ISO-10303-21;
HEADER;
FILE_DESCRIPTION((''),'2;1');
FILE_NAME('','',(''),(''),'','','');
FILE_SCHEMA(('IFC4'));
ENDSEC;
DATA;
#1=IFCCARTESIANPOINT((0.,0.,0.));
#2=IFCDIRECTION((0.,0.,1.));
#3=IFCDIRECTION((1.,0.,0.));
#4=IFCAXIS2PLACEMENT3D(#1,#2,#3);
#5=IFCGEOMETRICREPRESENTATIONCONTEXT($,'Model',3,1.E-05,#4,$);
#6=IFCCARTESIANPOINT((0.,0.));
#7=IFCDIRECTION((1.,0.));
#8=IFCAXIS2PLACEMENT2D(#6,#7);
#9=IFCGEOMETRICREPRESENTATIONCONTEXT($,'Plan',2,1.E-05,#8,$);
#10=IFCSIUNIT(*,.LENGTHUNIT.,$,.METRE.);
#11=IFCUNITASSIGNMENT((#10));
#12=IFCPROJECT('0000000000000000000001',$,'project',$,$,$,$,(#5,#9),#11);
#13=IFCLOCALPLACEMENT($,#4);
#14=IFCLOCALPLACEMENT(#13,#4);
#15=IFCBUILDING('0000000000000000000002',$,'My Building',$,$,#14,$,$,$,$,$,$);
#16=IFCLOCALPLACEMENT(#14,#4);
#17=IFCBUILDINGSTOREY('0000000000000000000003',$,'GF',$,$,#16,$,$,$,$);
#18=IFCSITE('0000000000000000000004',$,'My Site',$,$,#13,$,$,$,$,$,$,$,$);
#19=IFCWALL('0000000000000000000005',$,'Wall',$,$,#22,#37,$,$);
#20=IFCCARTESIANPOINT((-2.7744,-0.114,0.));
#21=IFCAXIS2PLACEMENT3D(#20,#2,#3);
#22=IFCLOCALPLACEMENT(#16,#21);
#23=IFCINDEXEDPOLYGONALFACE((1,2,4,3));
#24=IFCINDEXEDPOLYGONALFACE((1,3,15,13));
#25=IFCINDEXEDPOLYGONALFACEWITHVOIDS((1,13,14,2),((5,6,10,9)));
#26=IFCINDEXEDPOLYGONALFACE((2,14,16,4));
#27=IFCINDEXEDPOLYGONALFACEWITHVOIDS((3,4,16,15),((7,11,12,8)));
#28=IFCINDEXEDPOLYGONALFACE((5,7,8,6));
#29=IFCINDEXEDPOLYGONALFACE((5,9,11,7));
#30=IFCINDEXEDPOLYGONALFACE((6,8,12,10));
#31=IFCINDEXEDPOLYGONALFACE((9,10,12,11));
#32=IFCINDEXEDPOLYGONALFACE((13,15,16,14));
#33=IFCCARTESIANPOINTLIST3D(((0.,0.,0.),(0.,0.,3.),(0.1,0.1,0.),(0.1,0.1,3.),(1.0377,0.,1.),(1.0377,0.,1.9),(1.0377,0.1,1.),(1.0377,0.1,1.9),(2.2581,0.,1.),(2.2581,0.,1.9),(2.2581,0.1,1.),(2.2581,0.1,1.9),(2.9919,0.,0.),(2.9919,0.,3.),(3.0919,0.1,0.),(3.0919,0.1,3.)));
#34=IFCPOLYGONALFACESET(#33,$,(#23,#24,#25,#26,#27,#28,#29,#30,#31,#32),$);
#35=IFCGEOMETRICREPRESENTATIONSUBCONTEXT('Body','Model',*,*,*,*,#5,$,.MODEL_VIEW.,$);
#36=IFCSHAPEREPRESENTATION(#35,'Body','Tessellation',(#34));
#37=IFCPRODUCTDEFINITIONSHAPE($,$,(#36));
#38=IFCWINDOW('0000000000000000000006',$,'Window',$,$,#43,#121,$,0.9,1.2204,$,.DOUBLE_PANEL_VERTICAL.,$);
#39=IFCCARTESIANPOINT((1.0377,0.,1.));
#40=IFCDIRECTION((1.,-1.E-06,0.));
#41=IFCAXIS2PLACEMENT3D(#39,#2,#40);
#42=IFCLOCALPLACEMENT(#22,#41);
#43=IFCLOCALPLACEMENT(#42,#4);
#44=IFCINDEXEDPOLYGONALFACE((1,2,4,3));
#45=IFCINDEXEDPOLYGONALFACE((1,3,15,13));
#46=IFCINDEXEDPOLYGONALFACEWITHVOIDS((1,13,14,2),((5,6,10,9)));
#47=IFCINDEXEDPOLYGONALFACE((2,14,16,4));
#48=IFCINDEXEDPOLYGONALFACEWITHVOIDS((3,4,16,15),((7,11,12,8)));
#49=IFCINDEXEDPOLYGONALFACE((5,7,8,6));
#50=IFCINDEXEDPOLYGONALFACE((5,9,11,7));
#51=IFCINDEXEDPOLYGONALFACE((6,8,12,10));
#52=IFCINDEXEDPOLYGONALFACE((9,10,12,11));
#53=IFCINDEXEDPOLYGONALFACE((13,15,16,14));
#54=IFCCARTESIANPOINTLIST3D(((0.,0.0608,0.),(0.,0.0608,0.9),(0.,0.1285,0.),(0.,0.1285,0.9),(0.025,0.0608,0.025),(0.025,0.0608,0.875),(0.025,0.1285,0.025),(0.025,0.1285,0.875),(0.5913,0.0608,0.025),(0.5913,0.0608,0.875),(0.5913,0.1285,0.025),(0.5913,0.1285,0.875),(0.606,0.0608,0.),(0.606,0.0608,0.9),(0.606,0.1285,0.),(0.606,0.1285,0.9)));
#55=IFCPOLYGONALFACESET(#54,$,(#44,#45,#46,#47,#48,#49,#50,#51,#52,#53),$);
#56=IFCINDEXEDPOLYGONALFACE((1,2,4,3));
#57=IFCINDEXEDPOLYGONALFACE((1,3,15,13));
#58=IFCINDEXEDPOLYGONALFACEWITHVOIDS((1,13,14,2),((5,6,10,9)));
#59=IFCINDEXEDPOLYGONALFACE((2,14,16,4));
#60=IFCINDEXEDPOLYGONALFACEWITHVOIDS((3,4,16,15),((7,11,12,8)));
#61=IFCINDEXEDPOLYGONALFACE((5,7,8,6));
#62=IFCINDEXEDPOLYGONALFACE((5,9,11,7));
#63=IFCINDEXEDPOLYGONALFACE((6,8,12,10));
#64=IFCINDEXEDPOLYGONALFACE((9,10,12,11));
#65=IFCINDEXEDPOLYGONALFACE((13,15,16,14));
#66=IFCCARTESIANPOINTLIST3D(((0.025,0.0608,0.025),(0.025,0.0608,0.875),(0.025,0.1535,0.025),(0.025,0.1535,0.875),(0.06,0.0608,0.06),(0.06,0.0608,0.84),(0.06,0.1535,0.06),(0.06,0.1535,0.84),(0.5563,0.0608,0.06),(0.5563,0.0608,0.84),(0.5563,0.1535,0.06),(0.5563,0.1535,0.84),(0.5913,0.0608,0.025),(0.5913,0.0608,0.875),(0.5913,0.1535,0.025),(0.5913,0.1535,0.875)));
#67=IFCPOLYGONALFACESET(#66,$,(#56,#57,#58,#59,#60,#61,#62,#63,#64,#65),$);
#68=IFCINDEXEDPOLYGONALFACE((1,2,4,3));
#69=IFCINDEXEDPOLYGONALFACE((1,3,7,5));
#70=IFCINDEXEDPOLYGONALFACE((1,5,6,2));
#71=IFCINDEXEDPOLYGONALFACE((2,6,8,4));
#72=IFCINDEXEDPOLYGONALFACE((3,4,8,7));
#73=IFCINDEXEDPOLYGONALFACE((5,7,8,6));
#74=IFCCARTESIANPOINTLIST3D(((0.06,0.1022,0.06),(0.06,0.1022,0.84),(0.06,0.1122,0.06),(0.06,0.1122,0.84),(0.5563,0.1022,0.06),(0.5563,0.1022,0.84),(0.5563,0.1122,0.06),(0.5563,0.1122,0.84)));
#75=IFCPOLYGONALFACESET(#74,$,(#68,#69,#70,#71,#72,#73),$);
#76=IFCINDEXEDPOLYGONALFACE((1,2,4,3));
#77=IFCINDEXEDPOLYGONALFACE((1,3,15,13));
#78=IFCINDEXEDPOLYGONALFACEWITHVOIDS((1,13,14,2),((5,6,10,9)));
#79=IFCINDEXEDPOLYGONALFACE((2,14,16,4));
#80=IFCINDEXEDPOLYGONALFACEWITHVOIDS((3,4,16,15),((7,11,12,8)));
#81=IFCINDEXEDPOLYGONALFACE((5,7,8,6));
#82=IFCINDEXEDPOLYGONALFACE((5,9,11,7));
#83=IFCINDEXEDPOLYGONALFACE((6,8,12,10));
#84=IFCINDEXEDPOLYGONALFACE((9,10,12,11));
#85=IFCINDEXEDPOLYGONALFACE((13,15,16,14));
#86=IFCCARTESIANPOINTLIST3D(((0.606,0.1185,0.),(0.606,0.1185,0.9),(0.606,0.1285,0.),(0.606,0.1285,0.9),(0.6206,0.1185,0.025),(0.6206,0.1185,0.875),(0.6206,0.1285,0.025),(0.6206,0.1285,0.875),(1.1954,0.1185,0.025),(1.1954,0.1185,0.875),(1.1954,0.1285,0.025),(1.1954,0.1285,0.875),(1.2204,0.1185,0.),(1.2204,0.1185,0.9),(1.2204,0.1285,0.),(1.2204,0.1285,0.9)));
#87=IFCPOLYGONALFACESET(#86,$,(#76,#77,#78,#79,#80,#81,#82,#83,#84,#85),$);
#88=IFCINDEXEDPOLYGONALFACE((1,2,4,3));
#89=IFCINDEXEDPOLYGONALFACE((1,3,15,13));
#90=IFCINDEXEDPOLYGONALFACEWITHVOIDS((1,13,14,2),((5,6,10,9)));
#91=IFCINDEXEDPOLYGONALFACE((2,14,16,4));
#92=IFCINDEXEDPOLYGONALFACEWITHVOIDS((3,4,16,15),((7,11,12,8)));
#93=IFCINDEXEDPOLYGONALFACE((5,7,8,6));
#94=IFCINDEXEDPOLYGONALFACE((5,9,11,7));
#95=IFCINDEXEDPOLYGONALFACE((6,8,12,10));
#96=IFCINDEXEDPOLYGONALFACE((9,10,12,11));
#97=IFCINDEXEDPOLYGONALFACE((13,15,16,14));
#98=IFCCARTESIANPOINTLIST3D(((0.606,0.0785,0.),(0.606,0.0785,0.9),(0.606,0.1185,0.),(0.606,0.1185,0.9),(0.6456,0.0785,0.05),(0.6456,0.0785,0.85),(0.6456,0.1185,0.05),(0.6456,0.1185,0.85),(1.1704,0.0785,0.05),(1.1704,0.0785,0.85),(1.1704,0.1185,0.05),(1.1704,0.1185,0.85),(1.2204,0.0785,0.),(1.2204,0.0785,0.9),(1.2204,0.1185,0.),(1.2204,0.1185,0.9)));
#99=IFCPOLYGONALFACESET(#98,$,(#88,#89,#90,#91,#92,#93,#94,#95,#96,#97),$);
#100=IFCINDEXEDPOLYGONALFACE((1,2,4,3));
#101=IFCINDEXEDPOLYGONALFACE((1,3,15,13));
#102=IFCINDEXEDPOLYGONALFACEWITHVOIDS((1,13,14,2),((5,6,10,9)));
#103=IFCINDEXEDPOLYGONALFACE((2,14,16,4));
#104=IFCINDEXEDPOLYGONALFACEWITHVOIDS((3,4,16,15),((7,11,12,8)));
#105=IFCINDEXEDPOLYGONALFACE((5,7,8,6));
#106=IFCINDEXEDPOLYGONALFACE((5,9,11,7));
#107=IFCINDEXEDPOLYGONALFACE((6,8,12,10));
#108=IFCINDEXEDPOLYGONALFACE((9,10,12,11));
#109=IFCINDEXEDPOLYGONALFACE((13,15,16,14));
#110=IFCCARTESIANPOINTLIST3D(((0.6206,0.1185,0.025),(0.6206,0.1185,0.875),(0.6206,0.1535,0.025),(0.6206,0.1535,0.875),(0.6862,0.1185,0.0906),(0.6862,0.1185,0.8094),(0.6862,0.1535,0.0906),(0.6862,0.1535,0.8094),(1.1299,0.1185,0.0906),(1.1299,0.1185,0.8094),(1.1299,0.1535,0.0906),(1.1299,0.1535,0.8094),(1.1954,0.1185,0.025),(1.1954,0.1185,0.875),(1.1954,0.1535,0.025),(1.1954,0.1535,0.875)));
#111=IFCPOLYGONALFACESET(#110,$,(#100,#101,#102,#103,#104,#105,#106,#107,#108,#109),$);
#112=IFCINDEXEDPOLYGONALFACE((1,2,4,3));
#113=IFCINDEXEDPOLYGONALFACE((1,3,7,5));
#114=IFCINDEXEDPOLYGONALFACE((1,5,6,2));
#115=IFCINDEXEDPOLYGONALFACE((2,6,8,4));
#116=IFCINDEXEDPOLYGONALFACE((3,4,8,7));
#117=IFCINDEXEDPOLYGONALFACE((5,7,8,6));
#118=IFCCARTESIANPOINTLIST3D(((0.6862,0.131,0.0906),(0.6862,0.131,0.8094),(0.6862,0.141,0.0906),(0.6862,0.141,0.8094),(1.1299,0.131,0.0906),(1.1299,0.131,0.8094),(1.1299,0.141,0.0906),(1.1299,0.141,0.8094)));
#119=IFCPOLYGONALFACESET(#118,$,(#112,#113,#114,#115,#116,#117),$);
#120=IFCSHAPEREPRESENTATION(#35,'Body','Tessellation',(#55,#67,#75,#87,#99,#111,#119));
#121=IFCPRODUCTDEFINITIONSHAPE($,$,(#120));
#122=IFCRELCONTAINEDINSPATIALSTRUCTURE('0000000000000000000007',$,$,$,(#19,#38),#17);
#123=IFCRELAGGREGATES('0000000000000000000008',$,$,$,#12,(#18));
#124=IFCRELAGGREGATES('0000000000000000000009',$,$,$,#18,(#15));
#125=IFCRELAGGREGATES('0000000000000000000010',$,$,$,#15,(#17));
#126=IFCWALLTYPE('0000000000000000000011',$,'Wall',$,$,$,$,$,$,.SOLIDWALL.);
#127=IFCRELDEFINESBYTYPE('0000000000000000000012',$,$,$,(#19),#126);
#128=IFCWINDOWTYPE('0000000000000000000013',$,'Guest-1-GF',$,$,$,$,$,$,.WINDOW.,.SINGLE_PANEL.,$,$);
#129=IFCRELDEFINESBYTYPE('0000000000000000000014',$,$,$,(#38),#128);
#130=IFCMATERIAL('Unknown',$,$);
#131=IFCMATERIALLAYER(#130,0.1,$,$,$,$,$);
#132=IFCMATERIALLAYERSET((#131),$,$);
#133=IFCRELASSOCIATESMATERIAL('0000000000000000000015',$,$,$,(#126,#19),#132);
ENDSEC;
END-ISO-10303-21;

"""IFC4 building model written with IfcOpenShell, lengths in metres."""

from ifc_helpers import new_model, entity, si_unit, frame, origin_with_axes, origin_2d_with_axis, place, context, subcontext, project, spatial, line, indexed_curve, outline, extrude, shape, source, transform, mapped, material, layer, layer_set, layer_usage, type_object, type_shapes, element, fill, save


model = new_model("IFC4")

# Units and contexts
model_context = context("Model", 3, precision=1e-05, world=origin_with_axes())
plan_context = context("Plan", 2, precision=1e-05, world=origin_2d_with_axis())
body_context_1 = subcontext(model_context, "Body", "Model", "MODEL_VIEW")
body_context_2 = subcontext(plan_context, "Body", "Plan", "PLAN_VIEW")
ifc_project = project(units=[si_unit("LENGTHUNIT", "METRE")], contexts=[model_context, plan_context])

# Site, building, storey
site_placement = place(None, origin_with_axes())
site = spatial("IfcSite", under=ifc_project, at=site_placement, Name="My Site")
building_placement = place(site_placement, origin_with_axes())
building = spatial("IfcBuilding", under=site, at=building_placement, Name="My Building")
storey_placement = place(building_placement, origin_with_axes())
storey = spatial("IfcBuildingStorey", under=building, at=storey_placement, Name="GF")

# Shared definitions
ifc_material = material(Name="Unknown")

# Shared definitions
ifc_layer_1 = layer(ifc_material, 0.1)
ifc_layer_set_1 = layer_set([ifc_layer_1])
wall_type = type_object("IfcWallType", Name="Wall", PredefinedType="SOLIDWALL", material=ifc_layer_set_1)

# Wall, opening, window
ifc_layer_usage_1 = layer_usage(ifc_layer_set_1, "AXIS2", "POSITIVE", 0.0)
wall_1_placement = place(storey_placement, frame((-2.7744, -0.114, 0.0), z_axis=(0.0, 0.0, 1.0), x_axis=(1.0, 0.0, 0.0)))
wall_1 = element("IfcWall", 1, at=wall_1_placement, inside=storey, type_object=wall_type, material=ifc_layer_usage_1, Name="Wall", context=body_context_1, shape_type="SweptSolid", body=[
    extrude(outline(indexed_curve([(0.0, 0.0), (0.1, 0.1), (3.0919, 0.1), (2.9919, 0.0)], segments=[line(1, 2, 3, 4, 1)])), origin_with_axes(), (0.0, 0.0, 1.0), 3.0),
])
shared_shape_1 = source(origin_with_axes(), body_context_1, "Body", "SweptSolid", [
    extrude(outline(indexed_curve([(0.0, 0.0), (1.2204, 0.0), (1.2204, 0.9), (0.0, 0.9)], segments=[line(1, 2, 3, 4, 1)])), frame((0.0, -0.6, 0.0), z_axis=(0.0, -1.0, 0.0), x_axis=(1.0, 0.0, 0.0)), (0.0, 0.0, -1.0), 1.2),
])
opening_1_placement = place(wall_1_placement, frame((1.0377, 0.0, 1.0), z_axis=(0.0, 0.0, 1.0), x_axis=(1.0, -0.000001, 0.0)))
opening_1 = element("IfcOpeningElement", 2, at=opening_1_placement, cuts=wall_1, PredefinedType="OPENING", context=body_context_1, shape_type="MappedRepresentation", body=[
    mapped(shared_shape_1, transform((0.0, 0.0, 0.0), x_axis=(1.0, 0.0, 0.0), y_axis=(0.0, 1.0, 0.0), z_axis=(0.0, 0.0, 1.0), scale=1.0)),
])
window_type_1 = type_object("IfcWindowType", Name="Guest-1-GF", PartitioningType="SINGLE_PANEL", PredefinedType="WINDOW")
shared_shape_2 = source(origin_with_axes(), body_context_1, "Body", "SweptSolid", [
    extrude(outline(indexed_curve([(0.0, 0.0), (0.606, 0.0), (0.606, 0.9), (0.0, 0.9)], segments=[line(1, 2, 3, 4, 1)]), holes=[indexed_curve([(0.025, 0.025), (0.5913, 0.025), (0.5913, 0.875), (0.025, 0.875)], segments=[line(1, 2, 3, 4, 1)])]), frame((0.0, 0.0608, 0.0), z_axis=(0.0, -1.0, 0.0), x_axis=(1.0, 0.0, 0.0)), (0.0, 0.0, -1.0), 0.0677),
    extrude(outline(indexed_curve([(0.0, 0.0), (0.606, 0.0), (0.606, 0.9), (0.0, 0.9)], segments=[line(1, 2, 3, 4, 1)]), holes=[indexed_curve([(0.05, 0.05), (0.5663, 0.05), (0.5663, 0.85), (0.05, 0.85)], segments=[line(1, 2, 3, 4, 1)])]), frame((0.0, 0.0785, 0.0), z_axis=(0.0, -1.0, 0.0), x_axis=(1.0, 0.0, 0.0)), (0.0, 0.0, -1.0), -0.0177),
    extrude(outline(indexed_curve([(0.0, 0.0), (0.5663, 0.0), (0.5663, 0.85), (0.0, 0.85)], segments=[line(1, 2, 3, 4, 1)]), holes=[indexed_curve([(0.035, 0.035), (0.5313, 0.035), (0.5313, 0.815), (0.035, 0.815)], segments=[line(1, 2, 3, 4, 1)])]), frame((0.025, 0.0608, 0.025), z_axis=(0.0, -1.0, 0.0), x_axis=(1.0, 0.0, 0.0)), (0.0, 0.0, -1.0), 0.0927),
    extrude(outline(indexed_curve([(0.035, 0.035), (0.5313, 0.035), (0.5313, 0.815), (0.035, 0.815)], segments=[line(1, 2, 3, 4, 1)])), frame((0.025, 0.1022, 0.025), z_axis=(0.0, -1.0, 0.0), x_axis=(1.0, 0.0, 0.0)), (0.0, 0.0, -1.0), 0.01),
    extrude(outline(indexed_curve([(0.0, 0.0), (0.6144, 0.0), (0.6144, 0.9), (0.0, 0.9)], segments=[line(1, 2, 3, 4, 1)]), holes=[indexed_curve([(0.0147, 0.025), (0.5894, 0.025), (0.5894, 0.875), (0.0147, 0.875)], segments=[line(1, 2, 3, 4, 1)])]), frame((0.606, 0.1185, 0.0), z_axis=(0.0, -1.0, 0.0), x_axis=(1.0, 0.0, 0.0)), (0.0, 0.0, -1.0), 0.01),
    extrude(outline(indexed_curve([(0.0, 0.0), (0.6144, 0.0), (0.6144, 0.9), (0.0, 0.9)], segments=[line(1, 2, 3, 4, 1)]), holes=[indexed_curve([(0.0397, 0.05), (0.5644, 0.05), (0.5644, 0.85), (0.0397, 0.85)], segments=[line(1, 2, 3, 4, 1)])]), frame((0.606, 0.0785, 0.0), z_axis=(0.0, -1.0, 0.0), x_axis=(1.0, 0.0, 0.0)), (0.0, 0.0, -1.0), 0.04),
    extrude(outline(indexed_curve([(0.0, 0.0), (0.5748, 0.0), (0.5748, 0.85), (0.0, 0.85)], segments=[line(1, 2, 3, 4, 1)]), holes=[indexed_curve([(0.0656, 0.0656), (0.5092, 0.0656), (0.5092, 0.7844), (0.0656, 0.7844)], segments=[line(1, 2, 3, 4, 1)])]), frame((0.6206, 0.1185, 0.025), z_axis=(0.0, -1.0, 0.0), x_axis=(1.0, 0.0, 0.0)), (0.0, 0.0, -1.0), 0.035),
    extrude(outline(indexed_curve([(0.0656, 0.0656), (0.5092, 0.0656), (0.5092, 0.7844), (0.0656, 0.7844)], segments=[line(1, 2, 3, 4, 1)])), frame((0.6206, 0.131, 0.025), z_axis=(0.0, -1.0, 0.0), x_axis=(1.0, 0.0, 0.0)), (0.0, 0.0, -1.0), 0.01),
])
shared_shape_3 = source(origin_with_axes(), body_context_2, "Body", "Curve2D", [
    entity("IfcIndexedPolyCurve", entity("IfcCartesianPointList2D", [[0.05, 0.0785], [0.5663, 0.0785]])),
    entity("IfcIndexedPolyCurve", entity("IfcCartesianPointList2D", [[0.0, 0.1285], [0.025, 0.1285], [0.025, 0.0608], [0.05, 0.0608], [0.05, 0.0785], [0.0, 0.0785]]), [entity("IfcLineIndex", [1, 2, 3, 4, 5, 6, 1])]),
    entity("IfcIndexedPolyCurve", entity("IfcCartesianPointList2D", [[0.606, 0.1285], [0.5913, 0.1285], [0.5913, 0.0608], [0.5663, 0.0608], [0.5663, 0.0785], [0.606, 0.0785]])),
    entity("IfcIndexedPolyCurve", entity("IfcCartesianPointList2D", [[0.025, 0.0608], [0.06, 0.0608], [0.06, 0.1535], [0.025, 0.1535]]), [entity("IfcLineIndex", [1, 2, 3, 4, 1])]),
    entity("IfcIndexedPolyCurve", entity("IfcCartesianPointList2D", [[0.5913, 0.0608], [0.5563, 0.0608], [0.5563, 0.1535], [0.5913, 0.1535]]), [entity("IfcLineIndex", [1, 2, 3, 4, 1])]),
    entity("IfcIndexedPolyCurve", entity("IfcCartesianPointList2D", [[0.06, 0.0608], [0.5563, 0.0608]])),
    entity("IfcIndexedPolyCurve", entity("IfcCartesianPointList2D", [[0.06, 0.1535], [0.5563, 0.1535]])),
    entity("IfcIndexedPolyCurve", entity("IfcCartesianPointList2D", [[0.06, 0.1072], [0.5563, 0.1072]])),
    entity("IfcIndexedPolyCurve", entity("IfcCartesianPointList2D", [[0.6456, 0.0785], [1.1704, 0.0785]])),
    entity("IfcIndexedPolyCurve", entity("IfcCartesianPointList2D", [[0.606, 0.1285], [0.6206, 0.1285], [0.6206, 0.1185], [0.6456, 0.1185], [0.6456, 0.0785], [0.606, 0.0785]])),
    entity("IfcIndexedPolyCurve", entity("IfcCartesianPointList2D", [[1.2204, 0.1285], [1.1954, 0.1285], [1.1954, 0.1185], [1.1704, 0.1185], [1.1704, 0.0785], [1.2204, 0.0785]]), [entity("IfcLineIndex", [1, 2, 3, 4, 5, 6, 1])]),
    entity("IfcIndexedPolyCurve", entity("IfcCartesianPointList2D", [[0.6206, 0.1185], [0.6862, 0.1185], [0.6862, 0.1535], [0.6206, 0.1535]]), [entity("IfcLineIndex", [1, 2, 3, 4, 1])]),
    entity("IfcIndexedPolyCurve", entity("IfcCartesianPointList2D", [[1.1954, 0.1185], [1.1299, 0.1185], [1.1299, 0.1535], [1.1954, 0.1535]]), [entity("IfcLineIndex", [1, 2, 3, 4, 1])]),
    entity("IfcIndexedPolyCurve", entity("IfcCartesianPointList2D", [[0.6862, 0.1185], [1.1299, 0.1185]])),
    entity("IfcIndexedPolyCurve", entity("IfcCartesianPointList2D", [[0.6862, 0.1535], [1.1299, 0.1535]])),
    entity("IfcIndexedPolyCurve", entity("IfcCartesianPointList2D", [[0.6862, 0.136], [1.1299, 0.136]])),
])
type_shapes(window_type_1, [shared_shape_2, shared_shape_3])
window_1_placement = place(opening_1_placement, origin_with_axes())
window_1 = element("IfcWindow", 3, at=window_1_placement, inside=storey, type_object=window_type_1, Name="Window", OverallHeight=0.9, OverallWidth=1.2204, PartitioningType="DOUBLE_PANEL_VERTICAL", shapes=[
    shape(body_context_1, "Body", "MappedRepresentation", [mapped(shared_shape_2, transform((0.0, 0.0, 0.0), x_axis=(1.0, 0.0, 0.0), y_axis=(0.0, 1.0, 0.0), z_axis=(0.0, 0.0, 1.0), scale=1.0))]),
    shape(body_context_2, "Body", "MappedRepresentation", [mapped(shared_shape_3, transform((0.0, 0.0, 0.0), x_axis=(1.0, 0.0, 0.0), y_axis=(0.0, 1.0, 0.0), z_axis=(0.0, 0.0, 1.0), scale=1.0))]),
])
fill(opening_1, window_1)

save(model, "model.ifc")
